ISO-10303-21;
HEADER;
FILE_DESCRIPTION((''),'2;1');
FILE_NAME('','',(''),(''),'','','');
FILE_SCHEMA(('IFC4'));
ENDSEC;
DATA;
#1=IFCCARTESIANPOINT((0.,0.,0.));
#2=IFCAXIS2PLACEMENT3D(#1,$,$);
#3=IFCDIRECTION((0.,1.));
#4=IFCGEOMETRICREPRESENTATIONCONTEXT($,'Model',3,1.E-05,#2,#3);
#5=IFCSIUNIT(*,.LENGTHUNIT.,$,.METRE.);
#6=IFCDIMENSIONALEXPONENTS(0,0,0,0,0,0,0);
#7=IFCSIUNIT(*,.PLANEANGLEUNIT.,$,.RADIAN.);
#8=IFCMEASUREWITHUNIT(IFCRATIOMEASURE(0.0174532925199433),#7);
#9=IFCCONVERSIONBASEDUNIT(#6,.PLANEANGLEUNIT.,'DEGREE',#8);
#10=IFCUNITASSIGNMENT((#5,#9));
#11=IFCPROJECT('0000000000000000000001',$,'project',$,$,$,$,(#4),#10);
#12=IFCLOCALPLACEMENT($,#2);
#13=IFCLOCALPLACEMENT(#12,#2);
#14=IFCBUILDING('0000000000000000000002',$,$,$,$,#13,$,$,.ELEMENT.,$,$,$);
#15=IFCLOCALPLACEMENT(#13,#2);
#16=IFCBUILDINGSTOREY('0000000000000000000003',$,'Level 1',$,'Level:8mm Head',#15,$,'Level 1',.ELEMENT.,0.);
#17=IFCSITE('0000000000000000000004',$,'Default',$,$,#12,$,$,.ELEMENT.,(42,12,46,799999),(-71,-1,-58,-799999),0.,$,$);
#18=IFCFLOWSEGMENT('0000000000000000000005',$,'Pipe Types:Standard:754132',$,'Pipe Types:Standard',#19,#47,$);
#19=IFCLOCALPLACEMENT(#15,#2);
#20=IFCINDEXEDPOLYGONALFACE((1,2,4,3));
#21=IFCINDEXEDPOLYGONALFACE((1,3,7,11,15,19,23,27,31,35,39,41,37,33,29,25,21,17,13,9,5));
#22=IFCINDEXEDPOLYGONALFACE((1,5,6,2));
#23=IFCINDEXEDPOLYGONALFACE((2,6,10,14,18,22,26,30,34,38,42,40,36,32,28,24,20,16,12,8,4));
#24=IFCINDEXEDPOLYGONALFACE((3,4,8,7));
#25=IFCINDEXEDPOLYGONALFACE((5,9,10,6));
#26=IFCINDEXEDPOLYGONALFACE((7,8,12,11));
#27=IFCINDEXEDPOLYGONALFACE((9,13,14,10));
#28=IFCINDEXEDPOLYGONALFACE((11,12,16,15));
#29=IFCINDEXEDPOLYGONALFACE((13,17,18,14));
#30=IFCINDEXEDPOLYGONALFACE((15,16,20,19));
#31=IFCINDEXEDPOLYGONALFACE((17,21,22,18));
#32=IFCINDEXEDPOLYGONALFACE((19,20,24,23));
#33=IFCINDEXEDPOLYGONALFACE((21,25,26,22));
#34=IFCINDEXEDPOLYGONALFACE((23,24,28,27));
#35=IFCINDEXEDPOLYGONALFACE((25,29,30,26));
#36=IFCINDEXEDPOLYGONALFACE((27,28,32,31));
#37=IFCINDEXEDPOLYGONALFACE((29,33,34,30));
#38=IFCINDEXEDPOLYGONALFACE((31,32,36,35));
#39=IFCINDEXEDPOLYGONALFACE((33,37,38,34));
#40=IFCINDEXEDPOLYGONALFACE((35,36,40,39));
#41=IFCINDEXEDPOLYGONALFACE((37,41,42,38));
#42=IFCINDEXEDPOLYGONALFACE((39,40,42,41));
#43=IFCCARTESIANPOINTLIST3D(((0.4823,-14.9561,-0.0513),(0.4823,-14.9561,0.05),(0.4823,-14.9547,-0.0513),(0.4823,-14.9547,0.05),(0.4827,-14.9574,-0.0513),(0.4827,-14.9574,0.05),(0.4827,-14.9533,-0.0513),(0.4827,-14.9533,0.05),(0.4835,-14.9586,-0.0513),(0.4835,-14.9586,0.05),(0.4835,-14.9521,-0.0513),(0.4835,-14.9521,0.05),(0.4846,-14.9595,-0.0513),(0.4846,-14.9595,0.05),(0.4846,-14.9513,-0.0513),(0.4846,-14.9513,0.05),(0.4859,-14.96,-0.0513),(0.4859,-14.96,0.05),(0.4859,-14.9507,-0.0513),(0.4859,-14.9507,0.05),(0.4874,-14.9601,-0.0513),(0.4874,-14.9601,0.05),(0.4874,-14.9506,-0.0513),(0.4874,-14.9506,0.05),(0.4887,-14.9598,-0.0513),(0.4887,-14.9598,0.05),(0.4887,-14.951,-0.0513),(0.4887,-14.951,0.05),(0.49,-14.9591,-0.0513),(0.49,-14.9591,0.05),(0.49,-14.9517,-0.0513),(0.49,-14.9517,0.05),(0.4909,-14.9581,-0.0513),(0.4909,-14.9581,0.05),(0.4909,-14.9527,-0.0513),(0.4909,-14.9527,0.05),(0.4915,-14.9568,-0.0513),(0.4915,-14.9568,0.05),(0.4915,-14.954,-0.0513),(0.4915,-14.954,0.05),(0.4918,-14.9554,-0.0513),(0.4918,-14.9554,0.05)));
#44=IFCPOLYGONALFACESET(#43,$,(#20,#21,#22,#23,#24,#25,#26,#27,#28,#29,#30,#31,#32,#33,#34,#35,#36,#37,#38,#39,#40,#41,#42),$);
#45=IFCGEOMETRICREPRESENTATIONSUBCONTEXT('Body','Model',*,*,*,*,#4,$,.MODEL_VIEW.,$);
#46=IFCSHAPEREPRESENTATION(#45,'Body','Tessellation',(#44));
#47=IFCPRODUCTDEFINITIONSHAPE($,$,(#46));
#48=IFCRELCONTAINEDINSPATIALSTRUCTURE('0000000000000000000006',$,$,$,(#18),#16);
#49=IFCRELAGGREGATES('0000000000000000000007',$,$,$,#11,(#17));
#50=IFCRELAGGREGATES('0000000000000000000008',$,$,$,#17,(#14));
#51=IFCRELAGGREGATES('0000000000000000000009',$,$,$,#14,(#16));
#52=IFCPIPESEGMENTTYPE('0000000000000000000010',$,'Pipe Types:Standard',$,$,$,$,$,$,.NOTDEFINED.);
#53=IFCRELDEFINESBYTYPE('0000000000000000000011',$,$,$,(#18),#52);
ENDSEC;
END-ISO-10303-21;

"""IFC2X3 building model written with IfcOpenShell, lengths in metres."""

from ifc_helpers import new_model, entity, si_unit, converted_unit, direction, frame, origin, origin_2d_with_axis, place, context, subcontext, project, spatial, circle, extrude, type_object, element, save


model = new_model("IFC2X3")

# Units and contexts
model_context = context("Model", 3, precision=1e-05, world=origin(), true_north=direction((0.0, 1.0)))
body_context = subcontext(model_context, "Body", "Model", "MODEL_VIEW")
ifc_project = project(units=[si_unit("LENGTHUNIT", "METRE"), converted_unit("PLANEANGLEUNIT", "DEGREE", entity("IfcRatioMeasure", 0.0174532925199433), si_unit("PLANEANGLEUNIT", "RADIAN"), dimensions=[0, 0, 0, 0, 0, 0, 0])], contexts=[model_context])

# Site, building, storey
site_placement = place(None, origin())
site = spatial("IfcSite", under=ifc_project, at=site_placement, Name="Default", CompositionType="ELEMENT", RefLatitude=(42, 12, 46, 799999), RefLongitude=(-71, -1, -58, -799999), RefElevation=0.0)
building_placement = place(site_placement, origin())
building = spatial("IfcBuilding", under=site, at=building_placement, CompositionType="ELEMENT")
storey_placement = place(building_placement, origin())
storey = spatial("IfcBuildingStorey", under=building, at=storey_placement, Name="Level 1", ObjectType="Level:8mm Head", LongName="Level 1", CompositionType="ELEMENT", Elevation=0.0)

# Flow segment
pipe_segment_type = type_object("IfcPipeSegmentType", Name="Pipe Types:Standard", PredefinedType="NOTDEFINED")
flow_segment_1_placement = place(storey_placement, origin())
element("IfcFlowSegment", 1, at=flow_segment_1_placement, inside=storey, type_object=pipe_segment_type, Name="Pipe Types:Standard:754132", ObjectType="Pipe Types:Standard", context=body_context, shape_type="SweptSolid", body=[
    extrude(circle(Radius=0.0048, at=origin_2d_with_axis()), frame((0.487, -14.9554, -0.0513)), (0.0, 0.0, 1.0), 0.1013),
])

save(model, "model.ifc")
